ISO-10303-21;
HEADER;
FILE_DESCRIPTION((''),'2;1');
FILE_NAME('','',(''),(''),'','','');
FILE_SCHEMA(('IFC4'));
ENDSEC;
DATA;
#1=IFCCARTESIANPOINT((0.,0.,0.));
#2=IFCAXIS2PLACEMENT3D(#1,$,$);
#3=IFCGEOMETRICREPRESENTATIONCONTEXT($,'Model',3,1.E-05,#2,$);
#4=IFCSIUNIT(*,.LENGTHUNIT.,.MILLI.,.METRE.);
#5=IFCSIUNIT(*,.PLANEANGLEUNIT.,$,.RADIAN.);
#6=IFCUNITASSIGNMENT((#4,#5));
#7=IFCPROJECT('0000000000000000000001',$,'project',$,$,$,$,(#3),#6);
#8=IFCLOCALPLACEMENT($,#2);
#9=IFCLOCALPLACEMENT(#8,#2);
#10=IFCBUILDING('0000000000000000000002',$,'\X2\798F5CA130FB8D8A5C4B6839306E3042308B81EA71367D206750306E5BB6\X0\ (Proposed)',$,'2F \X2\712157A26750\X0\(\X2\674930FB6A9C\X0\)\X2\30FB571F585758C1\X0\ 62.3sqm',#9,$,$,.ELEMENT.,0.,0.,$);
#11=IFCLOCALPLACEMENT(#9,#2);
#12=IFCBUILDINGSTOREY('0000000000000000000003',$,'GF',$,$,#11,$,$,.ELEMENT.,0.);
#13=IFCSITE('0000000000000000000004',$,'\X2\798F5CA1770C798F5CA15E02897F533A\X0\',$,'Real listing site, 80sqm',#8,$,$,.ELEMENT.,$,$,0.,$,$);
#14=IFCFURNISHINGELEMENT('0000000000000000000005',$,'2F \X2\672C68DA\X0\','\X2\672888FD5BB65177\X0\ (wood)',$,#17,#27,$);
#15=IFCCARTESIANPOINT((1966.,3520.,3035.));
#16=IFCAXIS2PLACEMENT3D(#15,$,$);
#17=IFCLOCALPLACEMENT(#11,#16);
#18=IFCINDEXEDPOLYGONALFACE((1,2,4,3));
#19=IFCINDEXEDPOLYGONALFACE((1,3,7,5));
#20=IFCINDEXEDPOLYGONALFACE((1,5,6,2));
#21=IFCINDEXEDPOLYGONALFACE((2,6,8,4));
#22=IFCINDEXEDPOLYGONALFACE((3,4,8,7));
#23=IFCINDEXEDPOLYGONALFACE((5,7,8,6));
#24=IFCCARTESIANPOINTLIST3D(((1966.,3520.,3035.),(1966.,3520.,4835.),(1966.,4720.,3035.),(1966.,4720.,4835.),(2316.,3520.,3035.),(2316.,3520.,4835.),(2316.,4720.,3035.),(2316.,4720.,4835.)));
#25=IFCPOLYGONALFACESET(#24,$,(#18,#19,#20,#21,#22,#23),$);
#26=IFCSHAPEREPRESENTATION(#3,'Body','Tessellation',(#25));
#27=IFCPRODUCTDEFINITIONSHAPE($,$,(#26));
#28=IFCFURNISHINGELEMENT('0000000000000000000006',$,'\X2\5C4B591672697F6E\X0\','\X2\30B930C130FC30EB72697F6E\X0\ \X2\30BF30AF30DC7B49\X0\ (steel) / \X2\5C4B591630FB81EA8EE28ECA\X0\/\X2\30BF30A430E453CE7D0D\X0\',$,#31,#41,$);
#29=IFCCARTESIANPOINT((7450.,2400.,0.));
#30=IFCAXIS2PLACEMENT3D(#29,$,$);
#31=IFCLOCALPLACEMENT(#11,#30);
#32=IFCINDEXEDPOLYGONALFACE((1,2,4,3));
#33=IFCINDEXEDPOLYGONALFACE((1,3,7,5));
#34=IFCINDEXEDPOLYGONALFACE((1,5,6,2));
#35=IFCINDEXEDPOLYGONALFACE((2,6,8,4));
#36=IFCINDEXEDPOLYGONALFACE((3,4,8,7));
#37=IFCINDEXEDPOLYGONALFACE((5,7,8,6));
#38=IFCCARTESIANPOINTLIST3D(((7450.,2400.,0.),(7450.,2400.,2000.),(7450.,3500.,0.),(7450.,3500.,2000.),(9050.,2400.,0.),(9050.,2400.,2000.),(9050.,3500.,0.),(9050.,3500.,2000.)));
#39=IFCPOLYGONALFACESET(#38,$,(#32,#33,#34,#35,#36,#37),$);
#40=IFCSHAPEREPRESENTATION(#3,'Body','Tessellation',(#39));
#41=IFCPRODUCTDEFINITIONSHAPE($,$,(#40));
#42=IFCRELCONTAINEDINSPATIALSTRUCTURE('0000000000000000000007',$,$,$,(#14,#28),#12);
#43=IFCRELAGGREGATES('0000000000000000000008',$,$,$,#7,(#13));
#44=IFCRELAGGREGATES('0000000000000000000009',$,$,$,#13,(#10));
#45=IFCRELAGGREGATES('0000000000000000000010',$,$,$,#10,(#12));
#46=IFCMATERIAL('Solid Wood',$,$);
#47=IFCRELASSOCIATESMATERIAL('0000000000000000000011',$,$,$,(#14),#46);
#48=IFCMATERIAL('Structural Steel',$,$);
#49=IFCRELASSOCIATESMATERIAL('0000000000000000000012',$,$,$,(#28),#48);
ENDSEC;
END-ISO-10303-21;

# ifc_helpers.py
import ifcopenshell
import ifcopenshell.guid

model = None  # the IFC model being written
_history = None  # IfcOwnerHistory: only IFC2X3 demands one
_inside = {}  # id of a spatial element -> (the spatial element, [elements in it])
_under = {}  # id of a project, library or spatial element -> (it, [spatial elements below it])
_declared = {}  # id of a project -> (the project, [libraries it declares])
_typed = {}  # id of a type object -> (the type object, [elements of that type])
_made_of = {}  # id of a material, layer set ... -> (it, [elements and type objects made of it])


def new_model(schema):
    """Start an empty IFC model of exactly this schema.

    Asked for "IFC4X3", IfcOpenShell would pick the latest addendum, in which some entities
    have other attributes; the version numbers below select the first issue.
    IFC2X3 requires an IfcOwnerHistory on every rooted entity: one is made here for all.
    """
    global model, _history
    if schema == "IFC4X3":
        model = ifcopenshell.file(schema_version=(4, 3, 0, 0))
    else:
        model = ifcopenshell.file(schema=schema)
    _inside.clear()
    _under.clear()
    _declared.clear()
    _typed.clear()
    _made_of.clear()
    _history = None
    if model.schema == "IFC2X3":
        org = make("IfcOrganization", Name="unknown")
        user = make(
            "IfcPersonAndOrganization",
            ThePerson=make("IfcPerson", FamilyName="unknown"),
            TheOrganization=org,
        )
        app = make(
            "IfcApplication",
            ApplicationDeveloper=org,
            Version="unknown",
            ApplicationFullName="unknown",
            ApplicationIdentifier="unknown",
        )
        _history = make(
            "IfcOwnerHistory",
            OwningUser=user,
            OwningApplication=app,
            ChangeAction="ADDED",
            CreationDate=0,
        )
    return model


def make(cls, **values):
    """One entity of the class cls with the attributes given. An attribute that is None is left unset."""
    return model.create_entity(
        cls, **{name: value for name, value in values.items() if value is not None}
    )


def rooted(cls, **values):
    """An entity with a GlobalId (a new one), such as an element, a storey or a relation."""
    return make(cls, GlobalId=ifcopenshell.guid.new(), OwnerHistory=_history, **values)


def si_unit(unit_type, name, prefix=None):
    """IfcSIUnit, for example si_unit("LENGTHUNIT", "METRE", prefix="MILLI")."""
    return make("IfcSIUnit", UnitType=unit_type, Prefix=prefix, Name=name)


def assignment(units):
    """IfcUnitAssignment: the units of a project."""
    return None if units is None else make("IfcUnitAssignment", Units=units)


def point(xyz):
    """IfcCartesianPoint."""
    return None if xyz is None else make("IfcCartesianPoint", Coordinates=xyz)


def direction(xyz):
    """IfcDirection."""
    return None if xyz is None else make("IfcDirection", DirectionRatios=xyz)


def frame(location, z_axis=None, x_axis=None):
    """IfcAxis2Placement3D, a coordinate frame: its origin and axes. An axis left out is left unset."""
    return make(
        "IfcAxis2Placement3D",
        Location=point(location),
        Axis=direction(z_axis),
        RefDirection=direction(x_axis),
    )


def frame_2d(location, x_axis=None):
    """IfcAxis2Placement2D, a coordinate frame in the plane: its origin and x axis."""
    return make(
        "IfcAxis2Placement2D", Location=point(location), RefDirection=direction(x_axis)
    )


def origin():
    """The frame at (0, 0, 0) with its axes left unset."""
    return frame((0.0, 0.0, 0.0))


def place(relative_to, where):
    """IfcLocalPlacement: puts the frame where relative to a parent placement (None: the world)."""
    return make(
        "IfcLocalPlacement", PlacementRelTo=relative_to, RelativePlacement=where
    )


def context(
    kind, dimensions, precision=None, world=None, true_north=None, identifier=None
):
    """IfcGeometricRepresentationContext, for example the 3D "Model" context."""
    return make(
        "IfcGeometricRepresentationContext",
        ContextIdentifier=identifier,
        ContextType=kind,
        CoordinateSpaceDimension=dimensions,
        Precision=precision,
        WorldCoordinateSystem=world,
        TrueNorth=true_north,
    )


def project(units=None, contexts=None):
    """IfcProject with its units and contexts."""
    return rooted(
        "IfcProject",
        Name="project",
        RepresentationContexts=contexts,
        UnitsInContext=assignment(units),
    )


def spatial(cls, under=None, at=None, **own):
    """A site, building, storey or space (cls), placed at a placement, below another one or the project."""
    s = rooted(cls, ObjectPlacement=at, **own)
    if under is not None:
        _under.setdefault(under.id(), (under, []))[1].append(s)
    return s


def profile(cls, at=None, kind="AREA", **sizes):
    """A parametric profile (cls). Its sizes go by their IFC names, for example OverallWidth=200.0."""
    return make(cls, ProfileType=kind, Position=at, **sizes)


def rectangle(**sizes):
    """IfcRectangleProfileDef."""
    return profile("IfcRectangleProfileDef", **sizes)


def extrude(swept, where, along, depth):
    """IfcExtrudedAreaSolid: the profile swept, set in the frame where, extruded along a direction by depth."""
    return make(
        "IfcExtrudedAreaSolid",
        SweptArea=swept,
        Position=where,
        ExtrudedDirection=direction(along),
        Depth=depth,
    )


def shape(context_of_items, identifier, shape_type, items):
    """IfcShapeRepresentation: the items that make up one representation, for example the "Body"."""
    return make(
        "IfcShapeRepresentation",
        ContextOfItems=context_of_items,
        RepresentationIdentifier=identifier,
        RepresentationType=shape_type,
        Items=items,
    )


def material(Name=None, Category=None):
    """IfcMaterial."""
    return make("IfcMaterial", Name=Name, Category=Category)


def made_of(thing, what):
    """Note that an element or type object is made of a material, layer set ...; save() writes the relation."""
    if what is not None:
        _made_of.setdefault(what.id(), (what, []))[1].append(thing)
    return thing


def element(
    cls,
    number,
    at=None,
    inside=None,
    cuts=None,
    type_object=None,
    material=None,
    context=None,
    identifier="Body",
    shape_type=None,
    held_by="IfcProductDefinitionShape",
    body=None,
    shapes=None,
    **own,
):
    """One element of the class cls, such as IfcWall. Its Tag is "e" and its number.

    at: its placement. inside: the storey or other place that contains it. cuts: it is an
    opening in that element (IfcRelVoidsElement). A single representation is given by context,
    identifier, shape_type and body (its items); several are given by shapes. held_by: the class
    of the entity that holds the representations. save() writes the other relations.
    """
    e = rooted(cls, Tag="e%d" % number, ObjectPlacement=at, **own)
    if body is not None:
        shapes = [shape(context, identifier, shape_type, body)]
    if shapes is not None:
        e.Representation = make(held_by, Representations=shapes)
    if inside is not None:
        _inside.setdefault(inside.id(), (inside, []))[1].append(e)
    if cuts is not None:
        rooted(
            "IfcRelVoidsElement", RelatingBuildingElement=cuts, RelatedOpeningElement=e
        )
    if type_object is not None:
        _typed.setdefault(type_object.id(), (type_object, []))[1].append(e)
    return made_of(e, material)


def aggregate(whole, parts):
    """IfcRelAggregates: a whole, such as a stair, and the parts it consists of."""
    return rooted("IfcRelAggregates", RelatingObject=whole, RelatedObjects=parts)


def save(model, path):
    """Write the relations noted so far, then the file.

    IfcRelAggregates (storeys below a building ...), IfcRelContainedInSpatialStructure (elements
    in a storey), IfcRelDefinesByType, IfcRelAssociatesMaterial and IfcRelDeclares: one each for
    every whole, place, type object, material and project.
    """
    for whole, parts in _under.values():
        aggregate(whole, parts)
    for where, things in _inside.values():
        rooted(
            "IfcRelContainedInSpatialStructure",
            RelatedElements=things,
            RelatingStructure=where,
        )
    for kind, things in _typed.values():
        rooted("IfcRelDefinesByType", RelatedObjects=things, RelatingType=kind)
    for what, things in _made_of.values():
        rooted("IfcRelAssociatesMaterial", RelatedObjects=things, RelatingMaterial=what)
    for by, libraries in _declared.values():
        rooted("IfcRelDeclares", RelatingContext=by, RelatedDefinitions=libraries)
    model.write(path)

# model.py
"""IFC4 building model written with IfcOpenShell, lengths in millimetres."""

from ifc_helpers import new_model, si_unit, frame, frame_2d, origin, place, context, project, spatial, rectangle, extrude, material, element, save


model = new_model("IFC4")

# Units and contexts
model_context = context("Model", 3, precision=1e-05, world=origin())
ifc_project = project(units=[si_unit("LENGTHUNIT", "METRE", prefix="MILLI"), si_unit("PLANEANGLEUNIT", "RADIAN")], contexts=[model_context])

# Site, building, storey
site_placement = place(None, origin())
site = spatial("IfcSite", under=ifc_project, at=site_placement, Name="福岡県福岡市西区", ObjectType="Real listing site, 80sqm", CompositionType="ELEMENT", RefElevation=0.0)
building_placement = place(site_placement, origin())
building = spatial("IfcBuilding", under=site, at=building_placement, Name="福岡・越屋根のある自然素材の家 (Proposed)", ObjectType="2F 無垢材(杉・檜)・土塗壁 62.3sqm", CompositionType="ELEMENT", ElevationOfRefHeight=0.0, ElevationOfTerrain=0.0)
storey_placement = place(building_placement, origin())
storey = spatial("IfcBuildingStorey", under=building, at=storey_placement, Name="GF", CompositionType="ELEMENT", Elevation=0.0)

# Shared definitions
ifc_material_1 = material(Name="Solid Wood")

# Shared definitions
ifc_material_2 = material(Name="Structural Steel")

# Furnishing elements
furnishing_1_placement = place(storey_placement, frame((1966.0, 3520.0, 3035.0)))
element("IfcFurnishingElement", 1, at=furnishing_1_placement, inside=storey, material=ifc_material_1, Name="2F 本棚", Description="木製家具 (wood)", context=model_context, shape_type="SweptSolid", body=[
    extrude(rectangle(XDim=350.0, YDim=1200.0, at=frame_2d((175.0, 600.0))), frame((1966.0, 3520.0, 3035.0)), (0.0, 0.0, 1.0), 1800.0),
])
furnishing_2_placement = place(storey_placement, frame((7450.0, 2400.0, 0.0)))
element("IfcFurnishingElement", 2, at=furnishing_2_placement, inside=storey, material=ifc_material_2, Name="屋外物置", Description="スチール物置 タクボ等 (steel) / 屋外・自転車/タイヤ収納", context=model_context, shape_type="SweptSolid", body=[
    extrude(rectangle(XDim=1600.0, YDim=1100.0, at=frame_2d((800.0, 550.0))), frame((7450.0, 2400.0, 0.0)), (0.0, 0.0, 1.0), 2000.0),
])

save(model, "model.ifc")
